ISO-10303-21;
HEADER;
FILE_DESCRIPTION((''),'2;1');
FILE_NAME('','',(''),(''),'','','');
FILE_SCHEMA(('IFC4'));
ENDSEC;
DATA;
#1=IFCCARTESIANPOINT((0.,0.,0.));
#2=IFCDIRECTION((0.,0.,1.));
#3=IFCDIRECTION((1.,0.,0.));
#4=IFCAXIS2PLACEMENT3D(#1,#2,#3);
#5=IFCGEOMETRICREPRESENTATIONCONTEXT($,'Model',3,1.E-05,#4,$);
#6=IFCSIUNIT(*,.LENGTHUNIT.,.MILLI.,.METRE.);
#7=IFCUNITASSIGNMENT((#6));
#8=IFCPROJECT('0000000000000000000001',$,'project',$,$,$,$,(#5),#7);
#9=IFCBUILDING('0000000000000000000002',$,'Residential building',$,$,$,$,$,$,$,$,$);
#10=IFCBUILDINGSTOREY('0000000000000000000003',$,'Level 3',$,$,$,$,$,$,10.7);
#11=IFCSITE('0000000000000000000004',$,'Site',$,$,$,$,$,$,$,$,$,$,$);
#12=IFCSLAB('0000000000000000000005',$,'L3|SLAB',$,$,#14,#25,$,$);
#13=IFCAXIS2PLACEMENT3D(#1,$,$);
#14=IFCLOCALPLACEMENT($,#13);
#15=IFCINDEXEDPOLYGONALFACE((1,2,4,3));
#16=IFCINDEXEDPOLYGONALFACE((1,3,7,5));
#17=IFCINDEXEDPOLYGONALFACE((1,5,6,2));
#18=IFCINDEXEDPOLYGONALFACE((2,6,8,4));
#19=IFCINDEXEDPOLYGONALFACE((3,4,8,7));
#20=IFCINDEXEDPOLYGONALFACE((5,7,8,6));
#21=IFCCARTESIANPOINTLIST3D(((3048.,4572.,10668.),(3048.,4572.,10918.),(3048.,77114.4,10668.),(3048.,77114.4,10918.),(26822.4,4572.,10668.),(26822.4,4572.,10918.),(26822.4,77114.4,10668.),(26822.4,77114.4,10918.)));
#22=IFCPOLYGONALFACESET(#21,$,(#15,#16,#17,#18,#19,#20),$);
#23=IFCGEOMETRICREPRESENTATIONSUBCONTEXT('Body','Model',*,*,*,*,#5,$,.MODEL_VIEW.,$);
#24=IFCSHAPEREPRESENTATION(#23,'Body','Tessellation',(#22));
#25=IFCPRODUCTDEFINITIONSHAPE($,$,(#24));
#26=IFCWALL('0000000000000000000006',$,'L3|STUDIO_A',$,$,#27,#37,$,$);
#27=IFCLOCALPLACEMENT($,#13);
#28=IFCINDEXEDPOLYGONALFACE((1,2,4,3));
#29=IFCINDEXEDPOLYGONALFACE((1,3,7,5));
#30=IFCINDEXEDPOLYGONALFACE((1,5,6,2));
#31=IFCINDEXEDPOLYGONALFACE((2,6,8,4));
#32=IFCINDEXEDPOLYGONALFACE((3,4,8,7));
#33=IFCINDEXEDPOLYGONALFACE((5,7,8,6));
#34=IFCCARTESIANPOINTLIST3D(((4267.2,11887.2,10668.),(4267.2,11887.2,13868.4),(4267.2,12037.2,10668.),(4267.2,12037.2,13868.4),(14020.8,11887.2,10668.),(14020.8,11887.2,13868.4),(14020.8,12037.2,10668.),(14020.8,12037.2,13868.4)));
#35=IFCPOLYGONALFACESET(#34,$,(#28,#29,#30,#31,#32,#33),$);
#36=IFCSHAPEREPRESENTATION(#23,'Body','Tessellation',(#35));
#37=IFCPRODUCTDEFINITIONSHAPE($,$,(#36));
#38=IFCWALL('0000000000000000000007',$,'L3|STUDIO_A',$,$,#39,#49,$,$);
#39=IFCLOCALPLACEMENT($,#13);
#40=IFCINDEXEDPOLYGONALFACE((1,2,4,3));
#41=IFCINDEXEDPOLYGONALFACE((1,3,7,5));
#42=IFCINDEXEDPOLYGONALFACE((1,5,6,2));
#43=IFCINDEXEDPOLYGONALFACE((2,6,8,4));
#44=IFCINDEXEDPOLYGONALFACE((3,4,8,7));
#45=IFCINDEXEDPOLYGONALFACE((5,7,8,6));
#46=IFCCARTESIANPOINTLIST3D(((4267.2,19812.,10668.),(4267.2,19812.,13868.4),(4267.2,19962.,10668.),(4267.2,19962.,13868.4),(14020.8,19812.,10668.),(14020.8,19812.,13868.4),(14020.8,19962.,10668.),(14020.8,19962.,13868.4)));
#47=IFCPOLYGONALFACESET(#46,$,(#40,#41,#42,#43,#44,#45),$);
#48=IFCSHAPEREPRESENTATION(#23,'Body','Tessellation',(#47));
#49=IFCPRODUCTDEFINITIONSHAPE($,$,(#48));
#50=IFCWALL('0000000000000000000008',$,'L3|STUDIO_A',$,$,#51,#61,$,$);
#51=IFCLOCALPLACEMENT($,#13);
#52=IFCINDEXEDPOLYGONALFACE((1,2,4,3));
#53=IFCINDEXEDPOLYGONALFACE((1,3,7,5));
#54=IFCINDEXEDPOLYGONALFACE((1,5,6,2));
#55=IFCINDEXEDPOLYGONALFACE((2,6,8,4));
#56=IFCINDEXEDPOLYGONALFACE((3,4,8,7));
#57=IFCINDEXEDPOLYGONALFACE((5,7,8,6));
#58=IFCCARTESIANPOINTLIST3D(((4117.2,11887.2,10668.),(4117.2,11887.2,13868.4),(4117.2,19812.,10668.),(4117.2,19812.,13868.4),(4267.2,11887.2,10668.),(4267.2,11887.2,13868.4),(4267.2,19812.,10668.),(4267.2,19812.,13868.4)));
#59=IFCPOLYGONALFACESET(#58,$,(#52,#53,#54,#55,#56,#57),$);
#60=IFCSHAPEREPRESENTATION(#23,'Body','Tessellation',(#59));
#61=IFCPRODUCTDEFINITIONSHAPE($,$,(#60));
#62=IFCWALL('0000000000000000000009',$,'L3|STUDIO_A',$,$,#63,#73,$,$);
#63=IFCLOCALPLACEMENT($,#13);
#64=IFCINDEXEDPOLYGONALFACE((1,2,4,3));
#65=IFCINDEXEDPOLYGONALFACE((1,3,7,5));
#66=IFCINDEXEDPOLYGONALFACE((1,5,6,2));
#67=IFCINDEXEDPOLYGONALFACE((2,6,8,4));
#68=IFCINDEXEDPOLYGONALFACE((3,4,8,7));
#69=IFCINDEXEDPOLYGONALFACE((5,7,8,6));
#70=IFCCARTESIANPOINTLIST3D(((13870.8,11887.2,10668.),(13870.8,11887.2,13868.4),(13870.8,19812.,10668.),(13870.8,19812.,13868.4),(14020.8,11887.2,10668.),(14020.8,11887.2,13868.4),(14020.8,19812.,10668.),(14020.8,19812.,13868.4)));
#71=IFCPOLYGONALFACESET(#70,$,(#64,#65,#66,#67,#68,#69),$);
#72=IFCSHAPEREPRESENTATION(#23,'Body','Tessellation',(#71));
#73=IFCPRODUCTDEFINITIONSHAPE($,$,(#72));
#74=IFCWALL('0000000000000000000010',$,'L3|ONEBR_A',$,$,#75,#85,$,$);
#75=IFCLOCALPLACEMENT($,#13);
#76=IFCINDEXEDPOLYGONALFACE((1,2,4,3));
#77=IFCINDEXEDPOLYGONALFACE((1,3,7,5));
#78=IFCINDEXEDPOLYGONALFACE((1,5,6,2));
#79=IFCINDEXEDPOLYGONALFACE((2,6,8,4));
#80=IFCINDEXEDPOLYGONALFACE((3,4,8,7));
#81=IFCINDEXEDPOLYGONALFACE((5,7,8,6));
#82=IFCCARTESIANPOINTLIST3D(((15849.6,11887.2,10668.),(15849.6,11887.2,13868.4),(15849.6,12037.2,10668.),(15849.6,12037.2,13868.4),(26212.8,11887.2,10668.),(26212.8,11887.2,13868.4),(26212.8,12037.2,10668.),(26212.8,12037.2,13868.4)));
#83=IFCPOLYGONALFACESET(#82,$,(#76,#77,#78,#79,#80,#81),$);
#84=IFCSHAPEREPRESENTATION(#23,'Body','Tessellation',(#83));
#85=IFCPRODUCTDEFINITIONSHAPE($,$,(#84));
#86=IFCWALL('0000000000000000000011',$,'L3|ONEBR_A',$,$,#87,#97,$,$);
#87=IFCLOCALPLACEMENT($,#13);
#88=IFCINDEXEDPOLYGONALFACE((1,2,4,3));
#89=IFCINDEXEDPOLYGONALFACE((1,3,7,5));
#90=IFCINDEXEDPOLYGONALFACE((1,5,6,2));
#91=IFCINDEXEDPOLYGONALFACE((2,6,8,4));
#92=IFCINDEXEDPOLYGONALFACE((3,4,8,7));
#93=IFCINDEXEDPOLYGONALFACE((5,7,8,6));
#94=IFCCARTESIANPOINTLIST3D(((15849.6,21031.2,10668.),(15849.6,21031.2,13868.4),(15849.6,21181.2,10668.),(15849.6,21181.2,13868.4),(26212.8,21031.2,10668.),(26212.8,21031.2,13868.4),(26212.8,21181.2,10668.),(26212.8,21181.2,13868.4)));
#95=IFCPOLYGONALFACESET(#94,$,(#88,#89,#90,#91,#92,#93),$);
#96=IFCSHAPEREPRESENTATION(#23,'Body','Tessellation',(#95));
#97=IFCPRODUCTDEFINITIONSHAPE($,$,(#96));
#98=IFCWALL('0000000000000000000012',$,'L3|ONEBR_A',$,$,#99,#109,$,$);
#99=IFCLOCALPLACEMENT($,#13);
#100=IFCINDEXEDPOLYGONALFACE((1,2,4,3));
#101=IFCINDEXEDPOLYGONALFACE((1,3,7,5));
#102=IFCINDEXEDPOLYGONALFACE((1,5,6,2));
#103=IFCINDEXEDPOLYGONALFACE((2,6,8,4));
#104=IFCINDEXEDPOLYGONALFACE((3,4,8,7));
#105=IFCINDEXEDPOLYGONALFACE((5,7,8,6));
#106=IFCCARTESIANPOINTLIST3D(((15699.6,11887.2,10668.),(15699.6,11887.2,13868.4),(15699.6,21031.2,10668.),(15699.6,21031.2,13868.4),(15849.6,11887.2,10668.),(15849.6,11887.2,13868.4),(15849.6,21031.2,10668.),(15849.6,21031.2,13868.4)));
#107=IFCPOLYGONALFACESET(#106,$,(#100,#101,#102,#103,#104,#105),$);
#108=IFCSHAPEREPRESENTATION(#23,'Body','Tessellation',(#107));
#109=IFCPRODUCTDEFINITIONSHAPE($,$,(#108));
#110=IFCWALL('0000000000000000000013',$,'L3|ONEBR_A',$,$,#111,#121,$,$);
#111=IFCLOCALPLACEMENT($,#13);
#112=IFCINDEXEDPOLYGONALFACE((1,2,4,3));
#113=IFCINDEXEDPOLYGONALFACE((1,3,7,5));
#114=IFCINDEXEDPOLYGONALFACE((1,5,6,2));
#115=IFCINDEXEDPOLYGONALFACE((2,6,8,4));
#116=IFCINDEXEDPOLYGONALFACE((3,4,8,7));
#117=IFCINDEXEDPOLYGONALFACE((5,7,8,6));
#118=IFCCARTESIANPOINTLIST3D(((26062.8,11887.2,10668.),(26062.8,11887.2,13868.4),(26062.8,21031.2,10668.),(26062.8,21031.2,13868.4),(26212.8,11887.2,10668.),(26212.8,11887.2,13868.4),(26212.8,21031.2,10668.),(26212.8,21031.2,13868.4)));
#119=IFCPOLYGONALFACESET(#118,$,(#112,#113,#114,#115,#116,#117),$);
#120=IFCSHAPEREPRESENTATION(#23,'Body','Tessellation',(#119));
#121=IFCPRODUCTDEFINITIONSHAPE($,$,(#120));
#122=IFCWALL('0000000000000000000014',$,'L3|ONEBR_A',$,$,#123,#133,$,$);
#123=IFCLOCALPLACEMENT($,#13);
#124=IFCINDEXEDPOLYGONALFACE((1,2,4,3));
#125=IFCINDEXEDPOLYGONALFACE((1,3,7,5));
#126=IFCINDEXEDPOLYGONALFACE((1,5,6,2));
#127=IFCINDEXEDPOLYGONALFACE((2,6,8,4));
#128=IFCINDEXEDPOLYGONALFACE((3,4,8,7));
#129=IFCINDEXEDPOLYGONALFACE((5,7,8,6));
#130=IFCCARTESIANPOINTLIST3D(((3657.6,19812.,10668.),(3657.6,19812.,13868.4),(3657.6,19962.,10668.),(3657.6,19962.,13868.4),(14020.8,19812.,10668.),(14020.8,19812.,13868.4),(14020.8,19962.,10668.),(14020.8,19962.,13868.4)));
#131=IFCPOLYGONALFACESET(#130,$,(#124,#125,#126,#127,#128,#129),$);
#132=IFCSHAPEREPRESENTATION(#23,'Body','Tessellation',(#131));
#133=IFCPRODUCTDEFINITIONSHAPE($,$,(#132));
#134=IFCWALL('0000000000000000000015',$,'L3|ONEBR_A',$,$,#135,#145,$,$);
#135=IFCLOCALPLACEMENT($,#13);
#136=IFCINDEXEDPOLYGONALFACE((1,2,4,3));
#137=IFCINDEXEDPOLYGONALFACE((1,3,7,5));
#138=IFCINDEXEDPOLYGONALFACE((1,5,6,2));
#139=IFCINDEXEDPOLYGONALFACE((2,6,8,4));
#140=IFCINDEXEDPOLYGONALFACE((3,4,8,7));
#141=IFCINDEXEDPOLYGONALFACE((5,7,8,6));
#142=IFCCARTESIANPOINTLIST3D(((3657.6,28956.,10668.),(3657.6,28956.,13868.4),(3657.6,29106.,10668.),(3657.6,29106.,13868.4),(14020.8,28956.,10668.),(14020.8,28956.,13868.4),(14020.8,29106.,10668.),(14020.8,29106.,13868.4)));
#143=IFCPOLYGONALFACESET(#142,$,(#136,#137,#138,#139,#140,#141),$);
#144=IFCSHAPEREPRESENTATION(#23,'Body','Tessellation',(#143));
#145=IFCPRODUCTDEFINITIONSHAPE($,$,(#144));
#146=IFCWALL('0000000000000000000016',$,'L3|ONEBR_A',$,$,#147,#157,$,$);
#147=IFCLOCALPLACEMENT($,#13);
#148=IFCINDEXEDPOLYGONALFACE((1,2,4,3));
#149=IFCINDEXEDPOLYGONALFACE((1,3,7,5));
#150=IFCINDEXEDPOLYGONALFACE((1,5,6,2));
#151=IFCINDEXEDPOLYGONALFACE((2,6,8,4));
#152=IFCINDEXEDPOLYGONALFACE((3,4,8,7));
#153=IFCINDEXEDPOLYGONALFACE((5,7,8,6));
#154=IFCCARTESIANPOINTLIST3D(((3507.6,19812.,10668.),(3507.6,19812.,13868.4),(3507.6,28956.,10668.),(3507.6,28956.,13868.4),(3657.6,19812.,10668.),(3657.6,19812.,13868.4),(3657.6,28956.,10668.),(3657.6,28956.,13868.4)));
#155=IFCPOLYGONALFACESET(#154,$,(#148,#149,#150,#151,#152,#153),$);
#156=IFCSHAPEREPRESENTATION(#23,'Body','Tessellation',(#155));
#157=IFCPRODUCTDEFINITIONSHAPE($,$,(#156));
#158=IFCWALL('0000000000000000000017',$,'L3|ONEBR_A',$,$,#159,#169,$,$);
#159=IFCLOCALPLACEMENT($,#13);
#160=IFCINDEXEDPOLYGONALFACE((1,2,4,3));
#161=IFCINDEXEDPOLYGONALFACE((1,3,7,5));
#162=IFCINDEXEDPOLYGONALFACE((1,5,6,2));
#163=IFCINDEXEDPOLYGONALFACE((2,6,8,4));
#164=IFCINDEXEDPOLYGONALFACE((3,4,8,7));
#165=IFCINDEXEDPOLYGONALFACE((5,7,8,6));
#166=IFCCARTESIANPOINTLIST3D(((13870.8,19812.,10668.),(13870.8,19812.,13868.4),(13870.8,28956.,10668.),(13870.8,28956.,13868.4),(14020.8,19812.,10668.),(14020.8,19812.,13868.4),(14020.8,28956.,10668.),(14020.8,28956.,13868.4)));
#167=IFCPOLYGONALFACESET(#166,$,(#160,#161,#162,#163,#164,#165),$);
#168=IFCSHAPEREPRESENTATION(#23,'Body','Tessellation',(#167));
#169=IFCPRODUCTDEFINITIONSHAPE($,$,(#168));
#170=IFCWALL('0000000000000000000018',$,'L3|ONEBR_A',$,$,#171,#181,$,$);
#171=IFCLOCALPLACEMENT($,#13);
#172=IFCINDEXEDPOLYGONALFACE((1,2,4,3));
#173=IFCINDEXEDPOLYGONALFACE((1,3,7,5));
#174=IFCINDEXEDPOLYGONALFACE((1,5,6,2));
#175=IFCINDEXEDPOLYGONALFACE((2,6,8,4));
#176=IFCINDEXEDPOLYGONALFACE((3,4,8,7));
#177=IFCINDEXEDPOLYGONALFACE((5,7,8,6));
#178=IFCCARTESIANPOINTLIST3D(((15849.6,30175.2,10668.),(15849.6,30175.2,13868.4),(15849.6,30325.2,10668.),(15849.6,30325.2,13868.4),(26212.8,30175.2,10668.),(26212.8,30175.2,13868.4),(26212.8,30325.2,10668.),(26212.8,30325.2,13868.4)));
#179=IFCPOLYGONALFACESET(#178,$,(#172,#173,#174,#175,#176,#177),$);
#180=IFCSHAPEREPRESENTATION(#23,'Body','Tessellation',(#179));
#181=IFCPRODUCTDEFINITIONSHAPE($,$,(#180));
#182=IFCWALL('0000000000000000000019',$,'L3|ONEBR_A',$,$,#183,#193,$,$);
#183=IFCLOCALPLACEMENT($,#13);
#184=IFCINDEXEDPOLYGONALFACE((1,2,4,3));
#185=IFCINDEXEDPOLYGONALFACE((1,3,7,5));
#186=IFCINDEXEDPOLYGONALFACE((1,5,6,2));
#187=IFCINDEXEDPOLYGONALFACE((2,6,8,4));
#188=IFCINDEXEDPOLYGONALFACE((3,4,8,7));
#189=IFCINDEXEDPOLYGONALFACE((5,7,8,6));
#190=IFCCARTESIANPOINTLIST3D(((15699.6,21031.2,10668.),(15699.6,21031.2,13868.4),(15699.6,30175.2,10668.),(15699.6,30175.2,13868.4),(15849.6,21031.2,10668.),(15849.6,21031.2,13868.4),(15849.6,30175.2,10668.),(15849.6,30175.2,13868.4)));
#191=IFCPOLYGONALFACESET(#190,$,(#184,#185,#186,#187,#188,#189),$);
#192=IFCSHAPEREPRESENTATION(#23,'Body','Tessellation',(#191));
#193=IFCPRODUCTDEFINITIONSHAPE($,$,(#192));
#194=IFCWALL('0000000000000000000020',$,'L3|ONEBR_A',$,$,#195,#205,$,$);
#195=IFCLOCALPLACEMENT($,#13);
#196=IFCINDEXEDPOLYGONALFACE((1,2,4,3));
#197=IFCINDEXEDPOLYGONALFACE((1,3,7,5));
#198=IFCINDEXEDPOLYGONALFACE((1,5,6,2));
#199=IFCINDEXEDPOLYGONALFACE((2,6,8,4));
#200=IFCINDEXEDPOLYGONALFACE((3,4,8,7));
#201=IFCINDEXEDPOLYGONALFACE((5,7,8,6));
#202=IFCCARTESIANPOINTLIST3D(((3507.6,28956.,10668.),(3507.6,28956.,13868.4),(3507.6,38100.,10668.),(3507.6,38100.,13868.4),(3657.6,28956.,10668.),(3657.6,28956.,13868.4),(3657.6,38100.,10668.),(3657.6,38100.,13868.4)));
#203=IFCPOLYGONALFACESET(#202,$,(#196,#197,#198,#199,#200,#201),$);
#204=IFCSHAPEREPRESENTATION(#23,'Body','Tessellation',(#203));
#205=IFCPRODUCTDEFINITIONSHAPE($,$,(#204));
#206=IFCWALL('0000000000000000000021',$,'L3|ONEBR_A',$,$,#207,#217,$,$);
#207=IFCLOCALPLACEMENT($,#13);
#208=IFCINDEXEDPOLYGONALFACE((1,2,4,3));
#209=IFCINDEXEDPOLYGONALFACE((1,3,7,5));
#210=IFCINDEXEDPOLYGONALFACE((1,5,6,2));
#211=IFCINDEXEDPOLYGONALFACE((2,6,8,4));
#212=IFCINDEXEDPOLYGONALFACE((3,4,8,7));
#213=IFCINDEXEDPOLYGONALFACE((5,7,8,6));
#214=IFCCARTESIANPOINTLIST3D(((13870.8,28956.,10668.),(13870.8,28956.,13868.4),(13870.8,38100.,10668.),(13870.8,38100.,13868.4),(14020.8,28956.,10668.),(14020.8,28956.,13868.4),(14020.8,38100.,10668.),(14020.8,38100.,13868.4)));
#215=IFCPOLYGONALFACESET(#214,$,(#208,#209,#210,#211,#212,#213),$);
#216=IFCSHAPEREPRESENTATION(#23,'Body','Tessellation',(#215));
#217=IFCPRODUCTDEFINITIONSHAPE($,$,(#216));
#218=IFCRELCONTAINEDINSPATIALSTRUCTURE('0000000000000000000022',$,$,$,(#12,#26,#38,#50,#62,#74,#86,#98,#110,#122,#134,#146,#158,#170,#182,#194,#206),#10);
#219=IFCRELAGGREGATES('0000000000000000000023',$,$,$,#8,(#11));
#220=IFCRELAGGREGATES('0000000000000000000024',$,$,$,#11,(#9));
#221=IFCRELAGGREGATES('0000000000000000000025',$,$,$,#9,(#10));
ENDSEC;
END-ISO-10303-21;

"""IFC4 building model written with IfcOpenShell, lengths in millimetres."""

from ifc_helpers import new_model, si_unit, frame, origin_with_axes, place, context, subcontext, project, spatial, indexed_curve, outline, extrude, element, save


model = new_model("IFC4")

# Units and contexts
model_context = context("Model", 3, precision=1e-05, world=origin_with_axes())
body_context = subcontext(model_context, "Body", "Model", "MODEL_VIEW")
ifc_project = project(units=[si_unit("LENGTHUNIT", "METRE", prefix="MILLI")], contexts=[model_context])

# Site, building, storey
site = spatial("IfcSite", under=ifc_project, Name="Site")
building = spatial("IfcBuilding", under=site, Name="Residential building")
storey = spatial("IfcBuildingStorey", under=building, Name="Level 3", Elevation=10.7)

# Slab
slab_placement = place(None, frame((3048.0, 4572.0, 10668.0), z_axis=(0.0, 0.0, 1.0), x_axis=(1.0, 0.0, 0.0)))
element("IfcSlab", 1, at=slab_placement, inside=storey, Name="L3|SLAB", context=body_context, shape_type="SweptSolid", body=[
    extrude(outline(indexed_curve([(0.0, 0.0), (23774.4, 0.0), (23774.4, 72542.4), (0.0, 72542.4), (0.0, 0.0)])), None, (0.0, 0.0, 1.0), 250.0),
])

# Walls
for number, where, z_axis, x_axis, name in (
    (2, (4267.2, 11887.2, 10668.0), (0.0, 0.0, 1.0), (1.0, 0.0, 0.0), "L3|STUDIO_A"),
    (3, (4267.2, 19812.0, 10668.0), (0.0, 0.0, 1.0), (1.0, 0.0, 0.0), "L3|STUDIO_A"),
):
    element("IfcWall", number, at=place(None, frame(where, z_axis=z_axis, x_axis=x_axis)), inside=storey, Name=name, context=body_context, shape_type="SweptSolid", body=[
        extrude(outline(indexed_curve([(0.0, 0.0), (0.0, 150.0), (9753.6, 150.0), (9753.6, 0.0), (0.0, 0.0)], self_intersect=False)), origin_with_axes(), (0.0, 0.0, 1.0), 3200.4),
    ])
for number, where, z_axis, x_axis, name in (
    (4, (4267.2, 11887.2, 10668.0), (0.0, 0.0, 1.0), (0.0, 1.0, 0.0), "L3|STUDIO_A"),
    (5, (14020.8, 11887.2, 10668.0), (0.0, 0.0, 1.0), (0.0, 1.0, 0.0), "L3|STUDIO_A"),
):
    element("IfcWall", number, at=place(None, frame(where, z_axis=z_axis, x_axis=x_axis)), inside=storey, Name=name, context=body_context, shape_type="SweptSolid", body=[
        extrude(outline(indexed_curve([(0.0, 0.0), (0.0, 150.0), (7924.8, 150.0), (7924.8, 0.0), (0.0, 0.0)], self_intersect=False)), origin_with_axes(), (0.0, 0.0, 1.0), 3200.4),
    ])
for number, where, z_axis, x_axis, name in (
    (6, (15849.6, 11887.2, 10668.0), (0.0, 0.0, 1.0), (1.0, 0.0, 0.0), "L3|ONEBR_A"),
    (7, (15849.6, 21031.2, 10668.0), (0.0, 0.0, 1.0), (1.0, 0.0, 0.0), "L3|ONEBR_A"),
):
    element("IfcWall", number, at=place(None, frame(where, z_axis=z_axis, x_axis=x_axis)), inside=storey, Name=name, context=body_context, shape_type="SweptSolid", body=[
        extrude(outline(indexed_curve([(0.0, 0.0), (0.0, 150.0), (10363.2, 150.0), (10363.2, 0.0), (0.0, 0.0)], self_intersect=False)), origin_with_axes(), (0.0, 0.0, 1.0), 3200.4),
    ])
for number, where, z_axis, x_axis, name in (
    (8, (15849.6, 11887.2, 10668.0), (0.0, 0.0, 1.0), (0.0, 1.0, 0.0), "L3|ONEBR_A"),
    (9, (26212.8, 11887.2, 10668.0), (0.0, 0.0, 1.0), (0.0, 1.0, 0.0), "L3|ONEBR_A"),
):
    element("IfcWall", number, at=place(None, frame(where, z_axis=z_axis, x_axis=x_axis)), inside=storey, Name=name, context=body_context, shape_type="SweptSolid", body=[
        extrude(outline(indexed_curve([(0.0, 0.0), (0.0, 150.0), (9144.0, 150.0), (9144.0, 0.0), (0.0, 0.0)], self_intersect=False)), origin_with_axes(), (0.0, 0.0, 1.0), 3200.4),
    ])
for number, where, z_axis, x_axis, name in (
    (10, (3657.6, 19812.0, 10668.0), (0.0, 0.0, 1.0), (1.0, 0.0, 0.0), "L3|ONEBR_A"),
    (11, (3657.6, 28956.0, 10668.0), (0.0, 0.0, 1.0), (1.0, 0.0, 0.0), "L3|ONEBR_A"),
):
    element("IfcWall", number, at=place(None, frame(where, z_axis=z_axis, x_axis=x_axis)), inside=storey, Name=name, context=body_context, shape_type="SweptSolid", body=[
        extrude(outline(indexed_curve([(0.0, 0.0), (0.0, 150.0), (10363.2, 150.0), (10363.2, 0.0), (0.0, 0.0)], self_intersect=False)), origin_with_axes(), (0.0, 0.0, 1.0), 3200.4),
    ])
for number, where, z_axis, x_axis, name in (
    (12, (3657.6, 19812.0, 10668.0), (0.0, 0.0, 1.0), (0.0, 1.0, 0.0), "L3|ONEBR_A"),
    (13, (14020.8, 19812.0, 10668.0), (0.0, 0.0, 1.0), (0.0, 1.0, 0.0), "L3|ONEBR_A"),
):
    element("IfcWall", number, at=place(None, frame(where, z_axis=z_axis, x_axis=x_axis)), inside=storey, Name=name, context=body_context, shape_type="SweptSolid", body=[
        extrude(outline(indexed_curve([(0.0, 0.0), (0.0, 150.0), (9144.0, 150.0), (9144.0, 0.0), (0.0, 0.0)], self_intersect=False)), origin_with_axes(), (0.0, 0.0, 1.0), 3200.4),
    ])
for number, where, z_axis, x_axis, name in (
    (14, (15849.6, 30175.2, 10668.0), (0.0, 0.0, 1.0), (1.0, 0.0, 0.0), "L3|ONEBR_A"),
):
    element("IfcWall", number, at=place(None, frame(where, z_axis=z_axis, x_axis=x_axis)), inside=storey, Name=name, context=body_context, shape_type="SweptSolid", body=[
        extrude(outline(indexed_curve([(0.0, 0.0), (0.0, 150.0), (10363.2, 150.0), (10363.2, 0.0), (0.0, 0.0)], self_intersect=False)), origin_with_axes(), (0.0, 0.0, 1.0), 3200.4),
    ])
wall_1_placement = place(None, frame((15849.6, 21031.2, 10668.0), z_axis=(0.0, 0.0, 1.0), x_axis=(0.0, 1.0, 0.0)))
element("IfcWall", 15, at=wall_1_placement, inside=storey, Name="L3|ONEBR_A", context=body_context, shape_type="SweptSolid", body=[
    extrude(outline(indexed_curve([(0.0, 0.0), (0.0, 150.0), (9144.0, 150.0), (9144.0, 0.0), (0.0, 0.0)], self_intersect=False)), origin_with_axes(), (0.0, 0.0, 1.0), 3200.4),
])
for number, where, z_axis, x_axis, name in (
    (16, (3657.6, 28956.0, 10668.0), (0.0, 0.0, 1.0), (0.0, 1.0, 0.0), "L3|ONEBR_A"),
    (17, (14020.8, 28956.0, 10668.0), (0.0, 0.0, 1.0), (0.0, 1.0, 0.0), "L3|ONEBR_A"),
):
    element("IfcWall", number, at=place(None, frame(where, z_axis=z_axis, x_axis=x_axis)), inside=storey, Name=name, context=body_context, shape_type="SweptSolid", body=[
        extrude(outline(indexed_curve([(0.0, 0.0), (0.0, 150.0), (9144.0, 150.0), (9144.0, 0.0), (0.0, 0.0)], self_intersect=False)), origin_with_axes(), (0.0, 0.0, 1.0), 3200.4),
    ])

save(model, "model.ifc")
